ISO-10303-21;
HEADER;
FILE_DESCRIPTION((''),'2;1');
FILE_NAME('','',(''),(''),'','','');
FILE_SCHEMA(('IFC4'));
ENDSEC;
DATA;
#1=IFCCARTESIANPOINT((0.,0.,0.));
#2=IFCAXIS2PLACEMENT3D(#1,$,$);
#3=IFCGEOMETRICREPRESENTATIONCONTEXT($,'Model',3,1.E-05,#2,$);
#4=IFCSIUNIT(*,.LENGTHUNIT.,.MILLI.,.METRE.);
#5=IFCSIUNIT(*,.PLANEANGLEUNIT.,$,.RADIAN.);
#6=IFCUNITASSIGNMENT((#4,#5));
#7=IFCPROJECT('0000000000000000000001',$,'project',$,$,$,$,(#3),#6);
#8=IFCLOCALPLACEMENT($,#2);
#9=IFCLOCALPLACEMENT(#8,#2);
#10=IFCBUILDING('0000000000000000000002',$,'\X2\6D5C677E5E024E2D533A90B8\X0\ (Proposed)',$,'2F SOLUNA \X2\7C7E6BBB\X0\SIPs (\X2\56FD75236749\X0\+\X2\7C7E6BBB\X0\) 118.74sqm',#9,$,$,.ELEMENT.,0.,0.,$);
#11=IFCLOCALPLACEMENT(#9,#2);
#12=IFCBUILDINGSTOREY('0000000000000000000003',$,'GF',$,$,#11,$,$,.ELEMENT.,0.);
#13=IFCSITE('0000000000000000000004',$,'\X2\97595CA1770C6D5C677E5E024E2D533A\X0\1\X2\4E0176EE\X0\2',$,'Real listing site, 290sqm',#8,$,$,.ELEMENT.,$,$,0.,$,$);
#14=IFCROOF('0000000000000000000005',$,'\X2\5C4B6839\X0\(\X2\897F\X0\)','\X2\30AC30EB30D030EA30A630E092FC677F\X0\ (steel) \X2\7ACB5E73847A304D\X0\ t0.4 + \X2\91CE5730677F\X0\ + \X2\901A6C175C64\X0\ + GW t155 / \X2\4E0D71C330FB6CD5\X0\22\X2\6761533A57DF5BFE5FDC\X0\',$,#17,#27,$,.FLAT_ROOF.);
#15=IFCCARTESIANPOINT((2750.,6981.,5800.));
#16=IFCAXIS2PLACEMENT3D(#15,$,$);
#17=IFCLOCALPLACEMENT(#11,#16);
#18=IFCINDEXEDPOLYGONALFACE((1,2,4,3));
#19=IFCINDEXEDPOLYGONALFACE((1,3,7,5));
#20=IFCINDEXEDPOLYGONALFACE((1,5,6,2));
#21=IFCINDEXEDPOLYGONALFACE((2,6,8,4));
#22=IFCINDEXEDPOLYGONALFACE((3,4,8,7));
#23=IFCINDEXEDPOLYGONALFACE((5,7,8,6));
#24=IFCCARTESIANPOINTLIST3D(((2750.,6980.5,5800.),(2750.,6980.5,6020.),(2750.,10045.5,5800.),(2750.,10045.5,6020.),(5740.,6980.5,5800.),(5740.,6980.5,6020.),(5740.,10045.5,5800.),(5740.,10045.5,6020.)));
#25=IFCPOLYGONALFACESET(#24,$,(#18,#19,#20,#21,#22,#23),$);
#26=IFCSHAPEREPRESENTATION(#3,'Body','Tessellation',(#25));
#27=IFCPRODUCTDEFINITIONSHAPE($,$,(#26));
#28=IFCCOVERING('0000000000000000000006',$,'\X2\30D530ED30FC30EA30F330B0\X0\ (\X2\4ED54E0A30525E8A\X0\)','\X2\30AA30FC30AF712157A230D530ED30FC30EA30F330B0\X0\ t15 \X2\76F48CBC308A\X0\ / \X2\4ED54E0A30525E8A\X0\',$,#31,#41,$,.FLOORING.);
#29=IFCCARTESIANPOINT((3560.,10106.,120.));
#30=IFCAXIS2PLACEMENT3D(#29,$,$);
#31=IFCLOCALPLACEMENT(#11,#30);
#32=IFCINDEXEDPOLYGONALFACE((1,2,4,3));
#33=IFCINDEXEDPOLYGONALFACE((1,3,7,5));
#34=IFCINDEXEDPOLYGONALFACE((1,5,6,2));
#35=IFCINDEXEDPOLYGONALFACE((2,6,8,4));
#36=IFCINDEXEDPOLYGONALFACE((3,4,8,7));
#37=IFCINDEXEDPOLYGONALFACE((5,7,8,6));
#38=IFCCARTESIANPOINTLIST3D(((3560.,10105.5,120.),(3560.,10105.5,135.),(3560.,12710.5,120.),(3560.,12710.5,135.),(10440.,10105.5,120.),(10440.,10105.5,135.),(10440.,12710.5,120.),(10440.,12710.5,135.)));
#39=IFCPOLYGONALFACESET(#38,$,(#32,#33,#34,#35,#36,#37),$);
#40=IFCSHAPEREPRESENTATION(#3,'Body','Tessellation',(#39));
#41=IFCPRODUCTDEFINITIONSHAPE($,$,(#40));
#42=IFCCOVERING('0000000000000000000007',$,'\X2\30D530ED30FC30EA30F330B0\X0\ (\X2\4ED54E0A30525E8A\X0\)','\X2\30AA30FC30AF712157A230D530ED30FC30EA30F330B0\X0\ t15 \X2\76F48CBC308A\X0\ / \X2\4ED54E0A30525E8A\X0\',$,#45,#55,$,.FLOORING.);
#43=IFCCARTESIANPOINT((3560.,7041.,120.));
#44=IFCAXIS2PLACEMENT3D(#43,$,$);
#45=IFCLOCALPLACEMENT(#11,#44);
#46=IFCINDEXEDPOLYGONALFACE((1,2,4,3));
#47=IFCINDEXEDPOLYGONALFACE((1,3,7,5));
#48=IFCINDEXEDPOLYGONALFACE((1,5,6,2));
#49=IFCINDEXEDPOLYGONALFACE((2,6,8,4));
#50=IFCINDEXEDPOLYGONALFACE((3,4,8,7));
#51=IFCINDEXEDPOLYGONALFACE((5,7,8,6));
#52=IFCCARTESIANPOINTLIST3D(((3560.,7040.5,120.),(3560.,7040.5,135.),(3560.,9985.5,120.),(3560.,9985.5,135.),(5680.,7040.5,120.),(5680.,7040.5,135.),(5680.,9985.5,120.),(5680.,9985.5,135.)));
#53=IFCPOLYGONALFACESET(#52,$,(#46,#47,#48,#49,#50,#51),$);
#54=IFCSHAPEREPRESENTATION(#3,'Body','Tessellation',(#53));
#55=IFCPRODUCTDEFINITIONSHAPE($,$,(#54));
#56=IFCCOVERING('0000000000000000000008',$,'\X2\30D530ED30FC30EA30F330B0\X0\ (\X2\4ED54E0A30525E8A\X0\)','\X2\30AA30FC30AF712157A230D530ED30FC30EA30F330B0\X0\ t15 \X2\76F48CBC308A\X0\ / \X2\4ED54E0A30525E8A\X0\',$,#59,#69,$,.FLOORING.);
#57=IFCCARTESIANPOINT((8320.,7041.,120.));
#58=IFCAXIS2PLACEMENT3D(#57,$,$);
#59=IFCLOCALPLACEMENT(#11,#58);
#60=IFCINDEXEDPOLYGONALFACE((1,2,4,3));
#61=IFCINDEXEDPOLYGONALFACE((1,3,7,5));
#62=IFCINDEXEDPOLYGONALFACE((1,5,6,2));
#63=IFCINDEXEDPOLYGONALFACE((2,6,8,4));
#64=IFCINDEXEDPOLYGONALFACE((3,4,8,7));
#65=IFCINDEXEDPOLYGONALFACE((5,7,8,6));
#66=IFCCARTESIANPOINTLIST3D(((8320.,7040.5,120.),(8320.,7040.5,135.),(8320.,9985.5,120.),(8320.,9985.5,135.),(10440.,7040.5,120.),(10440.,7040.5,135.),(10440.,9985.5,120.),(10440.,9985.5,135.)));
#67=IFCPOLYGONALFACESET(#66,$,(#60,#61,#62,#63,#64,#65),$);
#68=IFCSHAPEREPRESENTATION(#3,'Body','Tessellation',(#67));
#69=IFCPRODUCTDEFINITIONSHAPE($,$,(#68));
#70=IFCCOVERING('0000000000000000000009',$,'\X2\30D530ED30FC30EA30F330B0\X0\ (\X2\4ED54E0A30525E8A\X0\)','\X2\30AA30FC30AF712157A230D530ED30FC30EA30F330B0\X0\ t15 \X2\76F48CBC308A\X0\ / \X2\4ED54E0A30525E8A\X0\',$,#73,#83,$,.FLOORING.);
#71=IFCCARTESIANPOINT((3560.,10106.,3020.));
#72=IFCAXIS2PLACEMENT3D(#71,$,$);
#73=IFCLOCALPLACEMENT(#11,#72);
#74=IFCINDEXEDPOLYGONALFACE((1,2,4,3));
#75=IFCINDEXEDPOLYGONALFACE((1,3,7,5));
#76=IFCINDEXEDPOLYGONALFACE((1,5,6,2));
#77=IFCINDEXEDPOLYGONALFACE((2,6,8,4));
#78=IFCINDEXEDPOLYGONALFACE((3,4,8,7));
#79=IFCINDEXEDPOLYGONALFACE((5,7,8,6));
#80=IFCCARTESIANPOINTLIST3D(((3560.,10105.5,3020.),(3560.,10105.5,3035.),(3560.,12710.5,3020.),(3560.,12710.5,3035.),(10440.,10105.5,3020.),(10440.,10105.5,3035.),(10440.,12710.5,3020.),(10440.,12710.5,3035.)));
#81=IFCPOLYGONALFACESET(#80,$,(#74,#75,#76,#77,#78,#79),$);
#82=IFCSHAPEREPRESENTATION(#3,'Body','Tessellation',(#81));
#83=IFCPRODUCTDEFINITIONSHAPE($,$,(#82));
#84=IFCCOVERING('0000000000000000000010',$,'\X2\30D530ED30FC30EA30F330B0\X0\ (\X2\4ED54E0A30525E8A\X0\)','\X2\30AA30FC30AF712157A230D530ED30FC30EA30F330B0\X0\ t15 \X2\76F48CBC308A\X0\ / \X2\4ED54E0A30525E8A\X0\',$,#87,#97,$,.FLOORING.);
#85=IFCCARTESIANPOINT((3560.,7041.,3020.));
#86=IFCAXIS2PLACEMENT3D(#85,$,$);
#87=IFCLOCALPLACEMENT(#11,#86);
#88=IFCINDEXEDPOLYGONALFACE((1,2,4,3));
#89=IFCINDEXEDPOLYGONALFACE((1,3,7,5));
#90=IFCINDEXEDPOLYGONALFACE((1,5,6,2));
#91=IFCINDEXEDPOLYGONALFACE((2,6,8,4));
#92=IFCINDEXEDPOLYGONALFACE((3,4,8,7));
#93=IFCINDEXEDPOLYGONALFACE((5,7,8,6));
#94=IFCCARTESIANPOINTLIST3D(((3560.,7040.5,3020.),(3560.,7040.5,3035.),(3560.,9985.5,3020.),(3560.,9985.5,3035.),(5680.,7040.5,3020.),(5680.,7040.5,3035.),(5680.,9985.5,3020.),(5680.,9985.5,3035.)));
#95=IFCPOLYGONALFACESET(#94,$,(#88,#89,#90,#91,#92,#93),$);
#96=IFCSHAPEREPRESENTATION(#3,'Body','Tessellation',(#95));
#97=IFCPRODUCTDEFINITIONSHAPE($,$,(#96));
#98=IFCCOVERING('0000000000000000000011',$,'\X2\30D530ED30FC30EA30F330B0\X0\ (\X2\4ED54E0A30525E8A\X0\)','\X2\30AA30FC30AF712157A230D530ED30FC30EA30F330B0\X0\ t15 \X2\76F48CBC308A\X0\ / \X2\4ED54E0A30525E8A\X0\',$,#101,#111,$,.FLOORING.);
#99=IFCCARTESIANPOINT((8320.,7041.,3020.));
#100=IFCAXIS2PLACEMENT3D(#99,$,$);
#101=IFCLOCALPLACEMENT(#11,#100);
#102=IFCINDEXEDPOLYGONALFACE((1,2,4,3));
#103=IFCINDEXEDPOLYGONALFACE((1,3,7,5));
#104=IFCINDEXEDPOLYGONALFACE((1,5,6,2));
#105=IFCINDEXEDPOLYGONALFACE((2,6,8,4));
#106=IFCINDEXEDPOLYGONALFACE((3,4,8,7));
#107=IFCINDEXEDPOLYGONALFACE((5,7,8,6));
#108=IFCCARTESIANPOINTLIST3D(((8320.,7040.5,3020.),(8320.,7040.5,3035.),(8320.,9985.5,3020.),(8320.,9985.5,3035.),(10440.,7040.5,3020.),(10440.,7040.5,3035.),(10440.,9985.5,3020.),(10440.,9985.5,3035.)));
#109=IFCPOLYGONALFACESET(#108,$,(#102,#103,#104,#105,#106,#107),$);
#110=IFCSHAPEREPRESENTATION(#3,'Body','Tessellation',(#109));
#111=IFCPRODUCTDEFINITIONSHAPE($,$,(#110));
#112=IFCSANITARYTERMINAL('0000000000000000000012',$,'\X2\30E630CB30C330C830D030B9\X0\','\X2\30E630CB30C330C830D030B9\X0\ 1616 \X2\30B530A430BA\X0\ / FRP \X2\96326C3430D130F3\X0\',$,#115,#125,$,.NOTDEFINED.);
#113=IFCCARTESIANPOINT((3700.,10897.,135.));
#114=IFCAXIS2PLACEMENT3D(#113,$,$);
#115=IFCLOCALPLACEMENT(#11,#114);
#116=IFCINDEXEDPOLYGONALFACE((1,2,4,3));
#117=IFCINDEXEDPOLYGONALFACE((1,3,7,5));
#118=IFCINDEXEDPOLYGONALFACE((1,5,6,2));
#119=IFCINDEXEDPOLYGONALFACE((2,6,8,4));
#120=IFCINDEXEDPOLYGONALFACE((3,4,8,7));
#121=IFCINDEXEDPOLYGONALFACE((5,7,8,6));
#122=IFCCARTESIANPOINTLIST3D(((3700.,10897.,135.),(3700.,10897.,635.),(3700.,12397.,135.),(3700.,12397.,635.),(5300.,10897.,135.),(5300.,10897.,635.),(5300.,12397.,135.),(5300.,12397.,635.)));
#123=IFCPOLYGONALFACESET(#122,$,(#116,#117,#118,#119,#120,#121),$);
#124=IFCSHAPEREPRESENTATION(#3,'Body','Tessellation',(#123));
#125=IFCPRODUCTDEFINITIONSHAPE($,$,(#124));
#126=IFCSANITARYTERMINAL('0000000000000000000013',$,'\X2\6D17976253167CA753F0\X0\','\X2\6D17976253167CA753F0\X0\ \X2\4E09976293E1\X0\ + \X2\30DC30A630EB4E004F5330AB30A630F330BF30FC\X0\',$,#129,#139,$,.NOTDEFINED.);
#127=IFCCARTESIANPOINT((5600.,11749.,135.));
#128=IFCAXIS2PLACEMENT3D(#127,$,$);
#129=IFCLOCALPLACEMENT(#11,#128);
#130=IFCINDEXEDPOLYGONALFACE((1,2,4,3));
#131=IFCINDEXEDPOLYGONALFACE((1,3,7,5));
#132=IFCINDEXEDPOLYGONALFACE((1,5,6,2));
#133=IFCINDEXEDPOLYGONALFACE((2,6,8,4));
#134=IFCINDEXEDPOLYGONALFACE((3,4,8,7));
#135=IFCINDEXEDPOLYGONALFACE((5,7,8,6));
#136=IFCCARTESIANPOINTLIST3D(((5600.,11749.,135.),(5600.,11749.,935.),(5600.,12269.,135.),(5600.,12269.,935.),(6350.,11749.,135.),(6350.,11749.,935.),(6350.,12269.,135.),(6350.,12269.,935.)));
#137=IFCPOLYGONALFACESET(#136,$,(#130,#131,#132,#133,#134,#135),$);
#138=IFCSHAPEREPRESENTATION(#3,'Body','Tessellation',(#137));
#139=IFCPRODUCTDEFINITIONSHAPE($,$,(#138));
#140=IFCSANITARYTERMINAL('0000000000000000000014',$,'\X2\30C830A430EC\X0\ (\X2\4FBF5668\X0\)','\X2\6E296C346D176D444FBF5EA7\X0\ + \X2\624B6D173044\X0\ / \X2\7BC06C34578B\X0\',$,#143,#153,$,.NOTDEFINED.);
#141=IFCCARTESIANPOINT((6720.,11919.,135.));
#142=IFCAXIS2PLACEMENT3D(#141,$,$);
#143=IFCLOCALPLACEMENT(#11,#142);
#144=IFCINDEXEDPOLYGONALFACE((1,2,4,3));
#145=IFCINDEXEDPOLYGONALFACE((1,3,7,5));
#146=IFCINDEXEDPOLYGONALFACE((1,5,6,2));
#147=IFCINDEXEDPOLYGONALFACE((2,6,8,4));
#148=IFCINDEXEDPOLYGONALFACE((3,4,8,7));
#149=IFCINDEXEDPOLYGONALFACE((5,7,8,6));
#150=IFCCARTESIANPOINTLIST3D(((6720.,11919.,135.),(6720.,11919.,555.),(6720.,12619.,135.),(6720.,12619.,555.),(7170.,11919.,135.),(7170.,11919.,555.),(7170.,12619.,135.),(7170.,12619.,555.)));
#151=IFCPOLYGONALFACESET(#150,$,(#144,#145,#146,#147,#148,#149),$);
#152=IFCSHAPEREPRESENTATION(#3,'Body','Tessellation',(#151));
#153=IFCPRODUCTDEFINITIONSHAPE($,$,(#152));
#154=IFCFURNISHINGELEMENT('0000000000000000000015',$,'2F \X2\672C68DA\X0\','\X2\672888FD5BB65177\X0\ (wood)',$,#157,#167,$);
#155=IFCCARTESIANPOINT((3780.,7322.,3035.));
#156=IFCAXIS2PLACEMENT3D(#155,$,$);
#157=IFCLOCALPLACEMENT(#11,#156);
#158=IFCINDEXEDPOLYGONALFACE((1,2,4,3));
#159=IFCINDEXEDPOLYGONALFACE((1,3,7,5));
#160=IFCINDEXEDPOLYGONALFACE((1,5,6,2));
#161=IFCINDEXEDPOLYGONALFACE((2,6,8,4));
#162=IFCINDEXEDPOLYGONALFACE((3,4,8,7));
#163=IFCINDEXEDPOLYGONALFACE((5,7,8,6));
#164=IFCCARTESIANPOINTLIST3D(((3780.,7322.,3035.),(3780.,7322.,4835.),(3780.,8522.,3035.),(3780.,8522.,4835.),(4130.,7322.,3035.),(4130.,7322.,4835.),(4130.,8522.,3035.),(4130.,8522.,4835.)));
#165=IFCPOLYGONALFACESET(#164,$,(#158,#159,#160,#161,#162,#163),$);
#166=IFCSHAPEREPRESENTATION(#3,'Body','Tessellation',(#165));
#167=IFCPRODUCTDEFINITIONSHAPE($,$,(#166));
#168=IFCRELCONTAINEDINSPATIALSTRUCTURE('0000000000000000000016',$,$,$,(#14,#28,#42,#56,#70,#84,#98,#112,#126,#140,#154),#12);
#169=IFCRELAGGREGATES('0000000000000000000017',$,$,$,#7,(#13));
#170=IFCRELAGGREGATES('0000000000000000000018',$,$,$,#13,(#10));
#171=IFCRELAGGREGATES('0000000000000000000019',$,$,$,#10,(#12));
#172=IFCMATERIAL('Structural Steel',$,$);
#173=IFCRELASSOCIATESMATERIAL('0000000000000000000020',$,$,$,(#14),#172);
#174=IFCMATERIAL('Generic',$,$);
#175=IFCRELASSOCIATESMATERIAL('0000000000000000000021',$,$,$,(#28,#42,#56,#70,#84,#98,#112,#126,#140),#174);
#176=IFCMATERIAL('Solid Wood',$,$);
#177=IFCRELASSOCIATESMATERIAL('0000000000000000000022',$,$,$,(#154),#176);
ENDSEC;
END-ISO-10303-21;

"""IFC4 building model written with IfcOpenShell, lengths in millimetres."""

from ifc_helpers import new_model, si_unit, frame, frame_2d, origin, place, context, project, spatial, rectangle, extrude, material, element, save


model = new_model("IFC4")

# Units and contexts
model_context = context("Model", 3, precision=1e-05, world=origin())
ifc_project = project(units=[si_unit("LENGTHUNIT", "METRE", prefix="MILLI"), si_unit("PLANEANGLEUNIT", "RADIAN")], contexts=[model_context])

# Site, building, storey
site_placement = place(None, origin())
site = spatial("IfcSite", under=ifc_project, at=site_placement, Name="静岡県浜松市中区1丁目2", ObjectType="Real listing site, 290sqm", CompositionType="ELEMENT", RefElevation=0.0)
building_placement = place(site_placement, origin())
building = spatial("IfcBuilding", under=site, at=building_placement, Name="浜松市中区邸 (Proposed)", ObjectType="2F SOLUNA 籾殻SIPs (国産杉+籾殻) 118.74sqm", CompositionType="ELEMENT", ElevationOfRefHeight=0.0, ElevationOfTerrain=0.0)
storey_placement = place(building_placement, origin())
storey = spatial("IfcBuildingStorey", under=building, at=storey_placement, Name="GF", CompositionType="ELEMENT", Elevation=0.0)

# Shared definitions
ifc_material_1 = material(Name="Solid Wood")

# Shared definitions
ifc_material_2 = material(Name="Generic")

# Roof
ifc_material_3 = material(Name="Structural Steel")
roof_1_placement = place(storey_placement, frame((2750.0, 6981.0, 5800.0)))
element("IfcRoof", 1, at=roof_1_placement, inside=storey, material=ifc_material_3, Name="屋根(西)", Description="ガルバリウム鋼板 (steel) 立平葺き t0.4 + 野地板 + 通気層 + GW t155 / 不燃・法22条区域対応", PredefinedType="FLAT_ROOF", context=model_context, shape_type="SweptSolid", body=[
    extrude(rectangle(XDim=2990.0, YDim=3065.0, at=frame_2d((1495.0, 1532.0))), frame((2750.0, 6981.0, 5800.0)), (0.0, 0.0, 1.0), 220.0),
])

# Coverings
covering_1_placement = place(storey_placement, frame((3560.0, 10106.0, 120.0)))
element("IfcCovering", 2, at=covering_1_placement, inside=storey, material=ifc_material_2, Name="フローリング (仕上げ床)", Description="オーク無垢フローリング t15 直貼り / 仕上げ床", PredefinedType="FLOORING", context=model_context, shape_type="SweptSolid", body=[
    extrude(rectangle(XDim=6880.0, YDim=2605.0, at=frame_2d((3440.0, 1302.0))), frame((3560.0, 10106.0, 120.0)), (0.0, 0.0, 1.0), 15.0),
])
covering_2_placement = place(storey_placement, frame((3560.0, 7041.0, 120.0)))
element("IfcCovering", 3, at=covering_2_placement, inside=storey, material=ifc_material_2, Name="フローリング (仕上げ床)", Description="オーク無垢フローリング t15 直貼り / 仕上げ床", PredefinedType="FLOORING", context=model_context, shape_type="SweptSolid", body=[
    extrude(rectangle(XDim=2120.0, YDim=2945.0, at=frame_2d((1060.0, 1472.0))), frame((3560.0, 7041.0, 120.0)), (0.0, 0.0, 1.0), 15.0),
])
covering_3_placement = place(storey_placement, frame((8320.0, 7041.0, 120.0)))
element("IfcCovering", 4, at=covering_3_placement, inside=storey, material=ifc_material_2, Name="フローリング (仕上げ床)", Description="オーク無垢フローリング t15 直貼り / 仕上げ床", PredefinedType="FLOORING", context=model_context, shape_type="SweptSolid", body=[
    extrude(rectangle(XDim=2120.0, YDim=2945.0, at=frame_2d((1060.0, 1472.0))), frame((8320.0, 7041.0, 120.0)), (0.0, 0.0, 1.0), 15.0),
])
covering_4_placement = place(storey_placement, frame((3560.0, 10106.0, 3020.0)))
element("IfcCovering", 5, at=covering_4_placement, inside=storey, material=ifc_material_2, Name="フローリング (仕上げ床)", Description="オーク無垢フローリング t15 直貼り / 仕上げ床", PredefinedType="FLOORING", context=model_context, shape_type="SweptSolid", body=[
    extrude(rectangle(XDim=6880.0, YDim=2605.0, at=frame_2d((3440.0, 1302.0))), frame((3560.0, 10106.0, 3020.0)), (0.0, 0.0, 1.0), 15.0),
])
covering_5_placement = place(storey_placement, frame((3560.0, 7041.0, 3020.0)))
element("IfcCovering", 6, at=covering_5_placement, inside=storey, material=ifc_material_2, Name="フローリング (仕上げ床)", Description="オーク無垢フローリング t15 直貼り / 仕上げ床", PredefinedType="FLOORING", context=model_context, shape_type="SweptSolid", body=[
    extrude(rectangle(XDim=2120.0, YDim=2945.0, at=frame_2d((1060.0, 1472.0))), frame((3560.0, 7041.0, 3020.0)), (0.0, 0.0, 1.0), 15.0),
])
covering_6_placement = place(storey_placement, frame((8320.0, 7041.0, 3020.0)))
element("IfcCovering", 7, at=covering_6_placement, inside=storey, material=ifc_material_2, Name="フローリング (仕上げ床)", Description="オーク無垢フローリング t15 直貼り / 仕上げ床", PredefinedType="FLOORING", context=model_context, shape_type="SweptSolid", body=[
    extrude(rectangle(XDim=2120.0, YDim=2945.0, at=frame_2d((1060.0, 1472.0))), frame((8320.0, 7041.0, 3020.0)), (0.0, 0.0, 1.0), 15.0),
])

# Sanitary terminals
sanitary_terminal_1_placement = place(storey_placement, frame((3700.0, 10897.0, 135.0)))
element("IfcSanitaryTerminal", 8, at=sanitary_terminal_1_placement, inside=storey, material=ifc_material_2, Name="ユニットバス", Description="ユニットバス 1616 サイズ / FRP 防水パン", PredefinedType="NOTDEFINED", context=model_context, shape_type="SweptSolid", body=[
    extrude(rectangle(XDim=1600.0, YDim=1500.0, at=frame_2d((800.0, 750.0))), frame((3700.0, 10897.0, 135.0)), (0.0, 0.0, 1.0), 500.0),
])
sanitary_terminal_2_placement = place(storey_placement, frame((5600.0, 11749.0, 135.0)))
element("IfcSanitaryTerminal", 9, at=sanitary_terminal_2_placement, inside=storey, material=ifc_material_2, Name="洗面化粧台", Description="洗面化粧台 三面鏡 + ボウル一体カウンター", PredefinedType="NOTDEFINED", context=model_context, shape_type="SweptSolid", body=[
    extrude(rectangle(XDim=750.0, YDim=520.0, at=frame_2d((375.0, 260.0))), frame((5600.0, 11749.0, 135.0)), (0.0, 0.0, 1.0), 800.0),
])
sanitary_terminal_3_placement = place(storey_placement, frame((6720.0, 11919.0, 135.0)))
element("IfcSanitaryTerminal", 10, at=sanitary_terminal_3_placement, inside=storey, material=ifc_material_2, Name="トイレ (便器)", Description="温水洗浄便座 + 手洗い / 節水型", PredefinedType="NOTDEFINED", context=model_context, shape_type="SweptSolid", body=[
    extrude(rectangle(XDim=450.0, YDim=700.0, at=frame_2d((225.0, 350.0))), frame((6720.0, 11919.0, 135.0)), (0.0, 0.0, 1.0), 420.0),
])

# Furnishing element
furnishing_placement = place(storey_placement, frame((3780.0, 7322.0, 3035.0)))
element("IfcFurnishingElement", 11, at=furnishing_placement, inside=storey, material=ifc_material_1, Name="2F 本棚", Description="木製家具 (wood)", context=model_context, shape_type="SweptSolid", body=[
    extrude(rectangle(XDim=350.0, YDim=1200.0, at=frame_2d((175.0, 600.0))), frame((3780.0, 7322.0, 3035.0)), (0.0, 0.0, 1.0), 1800.0),
])

save(model, "model.ifc")
